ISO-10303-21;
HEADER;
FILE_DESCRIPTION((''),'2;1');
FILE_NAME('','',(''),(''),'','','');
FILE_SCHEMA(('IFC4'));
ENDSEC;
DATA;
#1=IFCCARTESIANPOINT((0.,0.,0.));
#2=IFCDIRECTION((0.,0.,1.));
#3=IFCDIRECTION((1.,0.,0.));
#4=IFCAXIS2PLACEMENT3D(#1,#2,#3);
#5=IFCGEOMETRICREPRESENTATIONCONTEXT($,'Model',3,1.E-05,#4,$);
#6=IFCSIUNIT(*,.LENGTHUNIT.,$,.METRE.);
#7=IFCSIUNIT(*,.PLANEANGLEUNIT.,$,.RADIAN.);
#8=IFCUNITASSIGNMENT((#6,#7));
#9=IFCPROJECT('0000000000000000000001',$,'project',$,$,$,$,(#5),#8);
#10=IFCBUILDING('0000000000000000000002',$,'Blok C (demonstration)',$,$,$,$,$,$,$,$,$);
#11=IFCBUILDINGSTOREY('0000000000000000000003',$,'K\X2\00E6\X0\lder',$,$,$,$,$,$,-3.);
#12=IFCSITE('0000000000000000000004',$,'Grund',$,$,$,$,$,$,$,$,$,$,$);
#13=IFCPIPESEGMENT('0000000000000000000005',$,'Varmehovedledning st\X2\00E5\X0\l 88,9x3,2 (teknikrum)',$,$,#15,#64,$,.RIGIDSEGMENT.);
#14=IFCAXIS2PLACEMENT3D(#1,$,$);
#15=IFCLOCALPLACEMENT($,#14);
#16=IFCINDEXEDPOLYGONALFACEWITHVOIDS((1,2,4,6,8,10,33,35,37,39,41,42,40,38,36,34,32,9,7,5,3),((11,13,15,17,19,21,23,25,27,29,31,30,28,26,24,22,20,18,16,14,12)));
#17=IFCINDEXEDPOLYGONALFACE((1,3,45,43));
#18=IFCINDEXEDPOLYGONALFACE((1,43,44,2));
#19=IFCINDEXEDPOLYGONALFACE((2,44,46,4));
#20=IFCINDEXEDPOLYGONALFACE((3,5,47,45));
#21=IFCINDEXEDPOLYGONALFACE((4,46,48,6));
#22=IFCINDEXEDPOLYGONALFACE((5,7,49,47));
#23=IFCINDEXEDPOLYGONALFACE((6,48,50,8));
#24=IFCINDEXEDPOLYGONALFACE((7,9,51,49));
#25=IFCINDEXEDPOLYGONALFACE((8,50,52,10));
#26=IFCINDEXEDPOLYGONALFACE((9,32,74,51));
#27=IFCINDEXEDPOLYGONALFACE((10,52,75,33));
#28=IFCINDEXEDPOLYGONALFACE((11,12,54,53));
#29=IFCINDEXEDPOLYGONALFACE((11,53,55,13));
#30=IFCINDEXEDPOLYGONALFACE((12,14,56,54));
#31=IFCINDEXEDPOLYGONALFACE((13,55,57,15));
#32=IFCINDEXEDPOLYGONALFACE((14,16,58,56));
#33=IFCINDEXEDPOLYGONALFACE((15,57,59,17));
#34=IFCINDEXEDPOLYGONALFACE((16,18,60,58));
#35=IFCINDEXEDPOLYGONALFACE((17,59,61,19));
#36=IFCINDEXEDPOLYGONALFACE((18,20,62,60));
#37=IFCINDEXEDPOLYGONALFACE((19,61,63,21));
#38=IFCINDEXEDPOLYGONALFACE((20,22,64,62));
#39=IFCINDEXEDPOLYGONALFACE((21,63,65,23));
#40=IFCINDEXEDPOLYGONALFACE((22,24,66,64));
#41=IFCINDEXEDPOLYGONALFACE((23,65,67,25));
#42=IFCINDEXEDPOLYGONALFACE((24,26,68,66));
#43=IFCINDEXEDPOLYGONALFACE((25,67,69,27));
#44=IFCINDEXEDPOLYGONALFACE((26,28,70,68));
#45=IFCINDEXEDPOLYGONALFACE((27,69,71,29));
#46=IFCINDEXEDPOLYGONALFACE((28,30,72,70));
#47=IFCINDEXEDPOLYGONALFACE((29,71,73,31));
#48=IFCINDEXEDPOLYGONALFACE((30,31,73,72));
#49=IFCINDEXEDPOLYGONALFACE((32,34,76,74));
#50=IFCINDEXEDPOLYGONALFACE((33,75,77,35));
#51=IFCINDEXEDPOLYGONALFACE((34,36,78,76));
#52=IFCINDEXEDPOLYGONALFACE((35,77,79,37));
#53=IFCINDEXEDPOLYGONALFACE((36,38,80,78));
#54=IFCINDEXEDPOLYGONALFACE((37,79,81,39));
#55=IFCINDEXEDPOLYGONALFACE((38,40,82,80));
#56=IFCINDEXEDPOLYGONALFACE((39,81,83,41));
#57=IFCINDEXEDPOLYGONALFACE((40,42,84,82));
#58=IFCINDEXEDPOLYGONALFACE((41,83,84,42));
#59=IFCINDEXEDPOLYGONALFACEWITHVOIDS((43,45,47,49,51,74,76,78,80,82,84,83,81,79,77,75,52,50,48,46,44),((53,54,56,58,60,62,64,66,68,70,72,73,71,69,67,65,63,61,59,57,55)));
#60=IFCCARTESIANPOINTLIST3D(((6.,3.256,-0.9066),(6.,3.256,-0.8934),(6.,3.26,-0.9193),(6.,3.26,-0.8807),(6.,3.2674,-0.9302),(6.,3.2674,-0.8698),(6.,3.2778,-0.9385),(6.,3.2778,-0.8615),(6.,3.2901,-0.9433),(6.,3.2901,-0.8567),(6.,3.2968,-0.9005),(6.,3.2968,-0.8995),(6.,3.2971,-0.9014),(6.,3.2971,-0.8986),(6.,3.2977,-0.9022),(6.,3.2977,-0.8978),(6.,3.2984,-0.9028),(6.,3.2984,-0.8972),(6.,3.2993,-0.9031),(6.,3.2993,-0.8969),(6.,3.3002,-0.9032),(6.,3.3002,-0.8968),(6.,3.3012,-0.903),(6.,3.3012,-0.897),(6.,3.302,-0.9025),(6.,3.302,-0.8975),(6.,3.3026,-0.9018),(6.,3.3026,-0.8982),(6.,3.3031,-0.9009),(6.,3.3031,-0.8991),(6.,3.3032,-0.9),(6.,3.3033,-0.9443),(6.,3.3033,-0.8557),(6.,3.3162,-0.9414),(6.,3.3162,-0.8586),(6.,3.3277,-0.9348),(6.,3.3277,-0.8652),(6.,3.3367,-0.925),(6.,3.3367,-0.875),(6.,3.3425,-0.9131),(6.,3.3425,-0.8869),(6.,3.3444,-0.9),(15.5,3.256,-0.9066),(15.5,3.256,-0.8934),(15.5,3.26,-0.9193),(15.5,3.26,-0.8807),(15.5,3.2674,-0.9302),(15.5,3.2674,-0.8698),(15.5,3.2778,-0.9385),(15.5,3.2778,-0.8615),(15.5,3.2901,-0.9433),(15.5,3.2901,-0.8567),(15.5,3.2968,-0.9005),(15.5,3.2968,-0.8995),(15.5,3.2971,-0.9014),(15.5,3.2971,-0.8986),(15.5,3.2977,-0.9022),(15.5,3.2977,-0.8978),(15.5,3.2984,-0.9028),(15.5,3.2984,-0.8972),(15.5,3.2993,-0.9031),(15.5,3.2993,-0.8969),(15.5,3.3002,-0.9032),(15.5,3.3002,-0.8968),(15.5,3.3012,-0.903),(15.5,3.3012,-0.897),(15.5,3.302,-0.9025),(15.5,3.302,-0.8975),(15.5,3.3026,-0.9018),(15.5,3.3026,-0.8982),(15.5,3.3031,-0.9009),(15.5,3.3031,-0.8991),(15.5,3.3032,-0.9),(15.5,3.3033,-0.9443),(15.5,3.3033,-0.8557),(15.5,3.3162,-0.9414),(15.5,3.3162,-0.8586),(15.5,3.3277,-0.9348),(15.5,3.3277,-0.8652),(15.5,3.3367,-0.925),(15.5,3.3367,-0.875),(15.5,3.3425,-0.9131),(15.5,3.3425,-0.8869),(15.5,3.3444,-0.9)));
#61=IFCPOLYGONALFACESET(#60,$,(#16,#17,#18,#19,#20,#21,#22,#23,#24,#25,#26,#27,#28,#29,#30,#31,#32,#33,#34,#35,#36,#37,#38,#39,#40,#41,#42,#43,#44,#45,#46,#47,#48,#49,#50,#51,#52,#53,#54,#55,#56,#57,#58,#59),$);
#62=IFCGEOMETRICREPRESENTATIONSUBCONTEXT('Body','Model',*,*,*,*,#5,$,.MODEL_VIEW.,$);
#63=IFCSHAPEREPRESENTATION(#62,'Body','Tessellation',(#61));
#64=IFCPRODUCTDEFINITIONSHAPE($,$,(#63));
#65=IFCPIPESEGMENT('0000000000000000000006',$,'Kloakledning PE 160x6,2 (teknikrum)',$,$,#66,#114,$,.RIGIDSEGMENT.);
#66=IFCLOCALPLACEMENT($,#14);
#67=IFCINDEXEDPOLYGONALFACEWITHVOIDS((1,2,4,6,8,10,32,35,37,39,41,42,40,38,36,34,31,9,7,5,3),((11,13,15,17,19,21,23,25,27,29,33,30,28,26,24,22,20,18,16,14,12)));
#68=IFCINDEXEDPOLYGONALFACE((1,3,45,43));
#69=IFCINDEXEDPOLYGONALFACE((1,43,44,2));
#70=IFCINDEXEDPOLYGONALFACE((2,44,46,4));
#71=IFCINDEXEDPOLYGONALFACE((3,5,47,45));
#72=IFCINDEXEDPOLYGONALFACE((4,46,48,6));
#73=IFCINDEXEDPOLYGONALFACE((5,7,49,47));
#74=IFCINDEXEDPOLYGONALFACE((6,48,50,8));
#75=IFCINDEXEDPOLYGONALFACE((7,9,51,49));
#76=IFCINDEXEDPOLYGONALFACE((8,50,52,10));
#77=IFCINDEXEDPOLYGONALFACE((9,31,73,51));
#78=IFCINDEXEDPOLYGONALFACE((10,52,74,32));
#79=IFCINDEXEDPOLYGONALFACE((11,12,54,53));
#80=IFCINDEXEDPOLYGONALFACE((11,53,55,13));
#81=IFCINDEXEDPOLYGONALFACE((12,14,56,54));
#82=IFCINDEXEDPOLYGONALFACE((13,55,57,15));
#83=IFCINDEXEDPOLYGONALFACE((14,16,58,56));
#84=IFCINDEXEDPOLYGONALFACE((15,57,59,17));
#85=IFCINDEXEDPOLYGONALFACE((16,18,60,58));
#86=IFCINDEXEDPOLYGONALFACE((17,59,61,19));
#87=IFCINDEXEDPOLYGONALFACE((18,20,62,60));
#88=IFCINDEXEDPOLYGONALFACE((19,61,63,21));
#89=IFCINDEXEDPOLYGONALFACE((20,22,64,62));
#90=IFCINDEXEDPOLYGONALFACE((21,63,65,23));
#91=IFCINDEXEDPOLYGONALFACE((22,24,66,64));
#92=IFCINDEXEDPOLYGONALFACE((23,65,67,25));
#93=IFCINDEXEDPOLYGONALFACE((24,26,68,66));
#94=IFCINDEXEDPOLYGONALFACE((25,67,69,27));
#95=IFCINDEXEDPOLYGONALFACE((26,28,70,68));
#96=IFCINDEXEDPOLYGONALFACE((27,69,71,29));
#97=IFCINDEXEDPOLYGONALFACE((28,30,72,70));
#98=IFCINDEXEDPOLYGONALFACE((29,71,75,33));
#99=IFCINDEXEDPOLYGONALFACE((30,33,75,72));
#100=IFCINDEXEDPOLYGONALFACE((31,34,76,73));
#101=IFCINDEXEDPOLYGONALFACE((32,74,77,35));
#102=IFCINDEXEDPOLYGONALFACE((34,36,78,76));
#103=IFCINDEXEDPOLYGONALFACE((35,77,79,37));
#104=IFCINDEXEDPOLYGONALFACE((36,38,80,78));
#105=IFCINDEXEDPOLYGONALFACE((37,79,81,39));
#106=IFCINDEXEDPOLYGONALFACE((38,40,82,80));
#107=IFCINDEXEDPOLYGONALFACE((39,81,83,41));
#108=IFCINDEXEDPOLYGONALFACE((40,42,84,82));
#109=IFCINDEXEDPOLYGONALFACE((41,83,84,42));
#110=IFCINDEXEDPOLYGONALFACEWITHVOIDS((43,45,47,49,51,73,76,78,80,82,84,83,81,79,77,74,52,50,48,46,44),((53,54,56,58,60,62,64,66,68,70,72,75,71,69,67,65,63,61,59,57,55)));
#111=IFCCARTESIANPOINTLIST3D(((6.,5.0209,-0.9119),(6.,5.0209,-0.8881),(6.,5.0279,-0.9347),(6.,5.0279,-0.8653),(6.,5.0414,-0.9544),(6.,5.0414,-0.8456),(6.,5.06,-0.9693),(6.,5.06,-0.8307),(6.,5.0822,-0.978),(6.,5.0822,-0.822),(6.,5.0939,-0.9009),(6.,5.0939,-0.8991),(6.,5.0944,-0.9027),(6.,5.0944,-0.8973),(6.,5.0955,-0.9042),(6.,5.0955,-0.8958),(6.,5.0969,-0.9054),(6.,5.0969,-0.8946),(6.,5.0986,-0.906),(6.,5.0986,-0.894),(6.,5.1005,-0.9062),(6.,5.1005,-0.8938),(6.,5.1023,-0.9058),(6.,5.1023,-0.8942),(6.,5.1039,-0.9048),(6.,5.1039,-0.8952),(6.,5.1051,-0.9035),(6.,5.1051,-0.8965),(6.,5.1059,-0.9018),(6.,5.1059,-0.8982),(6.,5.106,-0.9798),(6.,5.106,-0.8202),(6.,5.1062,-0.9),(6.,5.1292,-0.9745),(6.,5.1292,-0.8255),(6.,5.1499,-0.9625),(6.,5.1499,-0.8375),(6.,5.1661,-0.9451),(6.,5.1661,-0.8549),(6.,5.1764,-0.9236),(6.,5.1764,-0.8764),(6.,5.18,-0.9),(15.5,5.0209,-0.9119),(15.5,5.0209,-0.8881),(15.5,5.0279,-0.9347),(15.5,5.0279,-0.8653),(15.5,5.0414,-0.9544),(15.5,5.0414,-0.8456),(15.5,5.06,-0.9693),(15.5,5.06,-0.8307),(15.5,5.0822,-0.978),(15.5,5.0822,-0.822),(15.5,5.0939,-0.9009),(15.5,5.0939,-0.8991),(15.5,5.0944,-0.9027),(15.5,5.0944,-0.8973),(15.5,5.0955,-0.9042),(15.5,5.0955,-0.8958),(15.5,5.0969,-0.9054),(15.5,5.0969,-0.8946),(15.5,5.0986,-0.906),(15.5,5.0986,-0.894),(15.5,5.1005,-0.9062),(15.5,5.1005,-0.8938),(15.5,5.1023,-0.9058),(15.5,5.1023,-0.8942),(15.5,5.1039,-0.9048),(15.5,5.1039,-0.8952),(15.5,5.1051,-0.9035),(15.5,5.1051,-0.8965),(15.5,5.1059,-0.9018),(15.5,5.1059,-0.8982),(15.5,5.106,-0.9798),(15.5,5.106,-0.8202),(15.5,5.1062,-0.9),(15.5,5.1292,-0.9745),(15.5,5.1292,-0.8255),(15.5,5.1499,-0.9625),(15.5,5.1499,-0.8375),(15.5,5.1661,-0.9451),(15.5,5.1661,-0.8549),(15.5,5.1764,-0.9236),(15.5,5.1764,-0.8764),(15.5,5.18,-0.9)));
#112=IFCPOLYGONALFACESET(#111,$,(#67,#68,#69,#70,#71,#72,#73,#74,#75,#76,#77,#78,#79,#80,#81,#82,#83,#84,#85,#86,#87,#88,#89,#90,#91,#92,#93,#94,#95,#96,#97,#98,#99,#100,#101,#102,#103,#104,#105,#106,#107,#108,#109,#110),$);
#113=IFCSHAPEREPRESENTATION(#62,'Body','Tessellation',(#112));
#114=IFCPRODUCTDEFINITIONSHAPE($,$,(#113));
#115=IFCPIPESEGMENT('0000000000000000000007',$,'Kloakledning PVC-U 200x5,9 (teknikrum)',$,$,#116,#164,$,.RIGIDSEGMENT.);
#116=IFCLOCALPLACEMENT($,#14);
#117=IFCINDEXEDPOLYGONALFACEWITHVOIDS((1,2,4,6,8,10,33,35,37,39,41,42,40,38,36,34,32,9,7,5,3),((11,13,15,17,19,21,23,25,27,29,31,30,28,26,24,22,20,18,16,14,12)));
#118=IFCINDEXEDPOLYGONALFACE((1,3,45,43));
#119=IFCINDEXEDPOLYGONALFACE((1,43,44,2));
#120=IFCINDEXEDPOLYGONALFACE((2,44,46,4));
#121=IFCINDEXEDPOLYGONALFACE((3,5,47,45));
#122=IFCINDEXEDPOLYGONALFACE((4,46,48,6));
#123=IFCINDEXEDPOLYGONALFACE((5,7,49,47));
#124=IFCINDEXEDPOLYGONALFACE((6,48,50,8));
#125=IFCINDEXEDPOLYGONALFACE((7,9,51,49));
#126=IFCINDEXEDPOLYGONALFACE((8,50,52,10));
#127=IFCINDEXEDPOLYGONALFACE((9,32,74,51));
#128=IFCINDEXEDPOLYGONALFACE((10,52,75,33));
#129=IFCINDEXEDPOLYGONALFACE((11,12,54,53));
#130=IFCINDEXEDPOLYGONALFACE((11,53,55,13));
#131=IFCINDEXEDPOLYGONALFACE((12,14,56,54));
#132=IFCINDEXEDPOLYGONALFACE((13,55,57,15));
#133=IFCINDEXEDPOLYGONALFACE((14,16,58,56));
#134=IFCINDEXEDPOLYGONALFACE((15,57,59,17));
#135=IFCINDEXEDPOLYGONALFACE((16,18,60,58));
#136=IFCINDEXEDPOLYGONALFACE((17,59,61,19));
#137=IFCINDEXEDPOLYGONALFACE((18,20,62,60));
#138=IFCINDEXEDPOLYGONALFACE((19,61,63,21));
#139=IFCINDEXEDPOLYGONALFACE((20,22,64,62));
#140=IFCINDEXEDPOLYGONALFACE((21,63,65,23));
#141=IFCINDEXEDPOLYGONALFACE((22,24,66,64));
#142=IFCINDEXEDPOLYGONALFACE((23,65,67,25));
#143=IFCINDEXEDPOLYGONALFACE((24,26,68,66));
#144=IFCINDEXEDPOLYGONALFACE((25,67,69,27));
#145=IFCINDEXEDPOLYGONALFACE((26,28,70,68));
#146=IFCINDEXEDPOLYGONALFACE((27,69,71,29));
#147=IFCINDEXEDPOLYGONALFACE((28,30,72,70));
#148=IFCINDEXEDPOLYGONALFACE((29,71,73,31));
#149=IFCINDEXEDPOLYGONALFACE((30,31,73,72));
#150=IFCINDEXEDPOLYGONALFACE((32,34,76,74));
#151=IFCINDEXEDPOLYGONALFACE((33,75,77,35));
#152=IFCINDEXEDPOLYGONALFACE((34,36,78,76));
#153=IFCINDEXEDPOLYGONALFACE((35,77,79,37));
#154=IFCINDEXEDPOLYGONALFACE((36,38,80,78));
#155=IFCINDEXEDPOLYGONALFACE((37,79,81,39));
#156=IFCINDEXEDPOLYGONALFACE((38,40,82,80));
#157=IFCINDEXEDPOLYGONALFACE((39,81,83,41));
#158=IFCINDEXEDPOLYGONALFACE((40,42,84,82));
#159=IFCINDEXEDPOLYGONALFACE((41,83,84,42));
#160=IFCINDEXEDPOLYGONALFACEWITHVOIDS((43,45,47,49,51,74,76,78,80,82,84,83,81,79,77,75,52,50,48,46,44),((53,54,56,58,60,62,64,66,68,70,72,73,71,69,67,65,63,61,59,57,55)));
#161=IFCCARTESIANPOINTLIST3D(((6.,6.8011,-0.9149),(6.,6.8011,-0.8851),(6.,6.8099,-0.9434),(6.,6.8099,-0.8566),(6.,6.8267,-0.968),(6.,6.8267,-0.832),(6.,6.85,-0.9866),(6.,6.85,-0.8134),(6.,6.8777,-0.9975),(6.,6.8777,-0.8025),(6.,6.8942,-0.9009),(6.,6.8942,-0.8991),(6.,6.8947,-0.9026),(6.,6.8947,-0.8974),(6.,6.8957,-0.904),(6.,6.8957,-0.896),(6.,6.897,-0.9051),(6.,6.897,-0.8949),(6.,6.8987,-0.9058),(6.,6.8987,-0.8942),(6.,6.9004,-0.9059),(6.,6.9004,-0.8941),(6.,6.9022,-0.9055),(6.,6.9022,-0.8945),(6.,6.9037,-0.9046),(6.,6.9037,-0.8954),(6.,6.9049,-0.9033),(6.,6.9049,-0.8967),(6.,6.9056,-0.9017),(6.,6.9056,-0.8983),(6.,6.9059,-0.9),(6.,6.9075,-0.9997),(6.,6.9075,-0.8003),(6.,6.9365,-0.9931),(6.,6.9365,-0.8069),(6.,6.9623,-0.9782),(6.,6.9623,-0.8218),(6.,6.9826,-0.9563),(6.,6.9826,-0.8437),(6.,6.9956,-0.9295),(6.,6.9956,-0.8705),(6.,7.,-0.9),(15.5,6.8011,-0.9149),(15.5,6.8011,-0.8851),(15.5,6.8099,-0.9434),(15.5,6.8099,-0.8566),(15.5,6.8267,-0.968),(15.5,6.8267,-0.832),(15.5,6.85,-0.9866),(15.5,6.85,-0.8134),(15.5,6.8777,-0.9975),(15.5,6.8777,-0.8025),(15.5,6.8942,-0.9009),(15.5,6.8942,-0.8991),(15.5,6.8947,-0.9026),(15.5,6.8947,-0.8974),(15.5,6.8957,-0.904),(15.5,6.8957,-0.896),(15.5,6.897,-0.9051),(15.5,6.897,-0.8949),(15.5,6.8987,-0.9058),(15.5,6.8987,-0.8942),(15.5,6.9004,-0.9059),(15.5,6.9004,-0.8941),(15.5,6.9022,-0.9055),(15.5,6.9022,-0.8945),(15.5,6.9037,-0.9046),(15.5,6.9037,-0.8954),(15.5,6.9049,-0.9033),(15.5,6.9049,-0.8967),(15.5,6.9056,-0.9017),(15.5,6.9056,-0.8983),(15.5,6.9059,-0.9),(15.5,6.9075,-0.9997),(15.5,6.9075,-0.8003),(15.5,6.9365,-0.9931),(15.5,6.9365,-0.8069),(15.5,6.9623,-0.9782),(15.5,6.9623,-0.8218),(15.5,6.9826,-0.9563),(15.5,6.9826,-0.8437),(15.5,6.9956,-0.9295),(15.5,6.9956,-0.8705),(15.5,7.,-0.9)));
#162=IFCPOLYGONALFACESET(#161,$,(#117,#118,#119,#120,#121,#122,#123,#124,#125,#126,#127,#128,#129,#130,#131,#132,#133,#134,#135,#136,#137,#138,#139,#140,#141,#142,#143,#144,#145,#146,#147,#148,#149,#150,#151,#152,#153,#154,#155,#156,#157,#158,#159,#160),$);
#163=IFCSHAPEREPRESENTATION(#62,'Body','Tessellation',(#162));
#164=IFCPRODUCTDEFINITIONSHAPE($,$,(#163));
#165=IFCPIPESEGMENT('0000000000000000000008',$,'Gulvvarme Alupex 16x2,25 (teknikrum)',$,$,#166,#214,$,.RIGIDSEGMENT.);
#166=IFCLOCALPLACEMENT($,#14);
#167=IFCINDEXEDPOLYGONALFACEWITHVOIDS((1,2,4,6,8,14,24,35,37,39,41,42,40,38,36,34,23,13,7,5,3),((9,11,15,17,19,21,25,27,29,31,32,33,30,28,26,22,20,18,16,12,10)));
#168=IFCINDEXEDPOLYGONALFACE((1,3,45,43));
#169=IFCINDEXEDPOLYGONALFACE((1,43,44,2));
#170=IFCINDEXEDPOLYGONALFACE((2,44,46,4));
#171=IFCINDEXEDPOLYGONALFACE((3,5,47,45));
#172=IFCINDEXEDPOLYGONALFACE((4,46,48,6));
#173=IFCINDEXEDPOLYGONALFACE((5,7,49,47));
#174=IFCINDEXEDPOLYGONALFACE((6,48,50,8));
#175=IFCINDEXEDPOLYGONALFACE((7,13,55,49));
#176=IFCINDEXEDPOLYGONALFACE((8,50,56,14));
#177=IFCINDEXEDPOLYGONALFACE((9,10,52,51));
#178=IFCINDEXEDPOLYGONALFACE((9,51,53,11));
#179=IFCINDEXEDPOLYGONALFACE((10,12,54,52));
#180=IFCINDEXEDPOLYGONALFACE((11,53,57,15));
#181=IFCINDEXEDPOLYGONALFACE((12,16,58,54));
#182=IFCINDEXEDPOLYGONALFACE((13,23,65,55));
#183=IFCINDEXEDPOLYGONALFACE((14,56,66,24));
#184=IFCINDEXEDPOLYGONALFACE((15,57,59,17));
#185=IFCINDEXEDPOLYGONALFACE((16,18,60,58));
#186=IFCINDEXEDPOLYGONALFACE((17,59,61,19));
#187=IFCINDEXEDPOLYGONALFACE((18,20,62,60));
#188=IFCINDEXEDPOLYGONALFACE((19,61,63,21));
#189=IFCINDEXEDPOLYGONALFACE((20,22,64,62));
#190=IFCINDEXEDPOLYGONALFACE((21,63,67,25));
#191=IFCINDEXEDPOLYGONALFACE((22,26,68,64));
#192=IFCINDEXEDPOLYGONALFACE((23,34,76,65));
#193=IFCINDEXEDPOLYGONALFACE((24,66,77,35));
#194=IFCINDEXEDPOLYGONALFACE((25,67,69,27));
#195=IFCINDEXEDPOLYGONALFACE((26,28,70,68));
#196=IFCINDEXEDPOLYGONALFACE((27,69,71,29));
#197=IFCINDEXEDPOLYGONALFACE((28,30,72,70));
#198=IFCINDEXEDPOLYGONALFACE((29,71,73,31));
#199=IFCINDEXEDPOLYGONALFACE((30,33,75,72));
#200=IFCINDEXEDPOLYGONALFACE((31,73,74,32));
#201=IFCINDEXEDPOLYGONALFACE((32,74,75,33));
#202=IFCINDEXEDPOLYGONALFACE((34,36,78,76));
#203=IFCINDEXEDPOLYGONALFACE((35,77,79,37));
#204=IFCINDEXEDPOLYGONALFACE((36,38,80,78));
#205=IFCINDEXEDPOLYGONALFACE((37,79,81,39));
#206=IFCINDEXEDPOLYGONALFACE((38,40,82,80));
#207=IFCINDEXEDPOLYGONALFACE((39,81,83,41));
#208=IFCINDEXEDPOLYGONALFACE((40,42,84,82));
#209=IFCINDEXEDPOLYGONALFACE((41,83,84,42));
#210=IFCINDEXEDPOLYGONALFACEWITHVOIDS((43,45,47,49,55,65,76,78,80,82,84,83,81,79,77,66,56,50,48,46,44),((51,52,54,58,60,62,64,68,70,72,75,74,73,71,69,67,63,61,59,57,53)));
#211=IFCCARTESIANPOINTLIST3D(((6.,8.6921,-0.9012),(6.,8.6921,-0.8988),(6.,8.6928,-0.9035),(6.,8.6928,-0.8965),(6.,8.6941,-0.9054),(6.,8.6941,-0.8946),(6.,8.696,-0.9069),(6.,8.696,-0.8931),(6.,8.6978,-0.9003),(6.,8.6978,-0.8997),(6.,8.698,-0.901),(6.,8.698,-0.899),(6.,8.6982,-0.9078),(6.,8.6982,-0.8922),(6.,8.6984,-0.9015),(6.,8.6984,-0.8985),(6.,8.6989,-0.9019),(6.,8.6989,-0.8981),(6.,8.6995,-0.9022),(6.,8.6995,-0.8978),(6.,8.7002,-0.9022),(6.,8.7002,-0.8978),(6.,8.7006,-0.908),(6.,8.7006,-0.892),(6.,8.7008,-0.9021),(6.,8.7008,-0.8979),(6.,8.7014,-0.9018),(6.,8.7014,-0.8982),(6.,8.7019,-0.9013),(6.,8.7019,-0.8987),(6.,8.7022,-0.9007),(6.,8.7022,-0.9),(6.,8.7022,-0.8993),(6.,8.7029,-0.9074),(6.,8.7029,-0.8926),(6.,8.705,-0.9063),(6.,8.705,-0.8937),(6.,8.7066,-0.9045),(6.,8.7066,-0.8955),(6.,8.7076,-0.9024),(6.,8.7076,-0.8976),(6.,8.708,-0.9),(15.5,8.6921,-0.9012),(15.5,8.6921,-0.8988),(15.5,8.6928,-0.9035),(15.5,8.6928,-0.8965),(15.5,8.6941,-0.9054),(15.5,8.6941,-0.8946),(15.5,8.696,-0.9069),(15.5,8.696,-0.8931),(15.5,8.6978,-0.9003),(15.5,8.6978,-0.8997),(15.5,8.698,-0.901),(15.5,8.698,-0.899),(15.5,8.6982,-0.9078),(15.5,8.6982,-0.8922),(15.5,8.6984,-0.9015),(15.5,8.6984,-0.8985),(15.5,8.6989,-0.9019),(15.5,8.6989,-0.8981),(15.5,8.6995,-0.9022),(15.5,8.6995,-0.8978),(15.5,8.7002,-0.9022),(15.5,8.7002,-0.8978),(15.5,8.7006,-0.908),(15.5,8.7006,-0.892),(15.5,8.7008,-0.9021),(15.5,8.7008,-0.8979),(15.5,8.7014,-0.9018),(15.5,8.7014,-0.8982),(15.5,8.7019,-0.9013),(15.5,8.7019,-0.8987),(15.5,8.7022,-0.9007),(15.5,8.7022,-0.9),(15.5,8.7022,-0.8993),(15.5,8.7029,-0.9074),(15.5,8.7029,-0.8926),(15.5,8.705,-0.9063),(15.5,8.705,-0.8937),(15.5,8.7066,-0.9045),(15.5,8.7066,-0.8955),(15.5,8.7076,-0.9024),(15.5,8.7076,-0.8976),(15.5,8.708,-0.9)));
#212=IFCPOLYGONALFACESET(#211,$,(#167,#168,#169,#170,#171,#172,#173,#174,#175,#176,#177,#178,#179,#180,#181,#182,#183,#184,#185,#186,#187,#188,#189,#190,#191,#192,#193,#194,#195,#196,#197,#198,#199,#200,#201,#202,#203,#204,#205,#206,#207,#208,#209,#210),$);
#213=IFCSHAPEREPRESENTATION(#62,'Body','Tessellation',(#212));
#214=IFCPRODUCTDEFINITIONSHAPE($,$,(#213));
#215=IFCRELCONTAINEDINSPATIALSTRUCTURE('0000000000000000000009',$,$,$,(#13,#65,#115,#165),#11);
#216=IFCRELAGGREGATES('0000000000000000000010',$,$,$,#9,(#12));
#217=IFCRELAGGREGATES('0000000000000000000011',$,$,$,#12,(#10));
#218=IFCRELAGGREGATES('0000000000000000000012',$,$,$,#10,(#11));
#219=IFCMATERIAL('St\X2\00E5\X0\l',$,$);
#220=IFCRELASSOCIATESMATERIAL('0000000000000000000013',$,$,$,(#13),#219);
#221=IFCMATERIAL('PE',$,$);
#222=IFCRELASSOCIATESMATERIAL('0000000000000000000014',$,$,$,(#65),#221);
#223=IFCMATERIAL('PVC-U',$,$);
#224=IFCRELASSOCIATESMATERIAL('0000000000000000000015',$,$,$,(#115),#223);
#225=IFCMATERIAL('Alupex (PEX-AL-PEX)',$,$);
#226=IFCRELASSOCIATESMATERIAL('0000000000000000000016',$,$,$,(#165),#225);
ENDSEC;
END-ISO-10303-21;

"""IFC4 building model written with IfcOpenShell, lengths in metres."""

from ifc_helpers import new_model, si_unit, frame, origin_with_axes, place, context, subcontext, project, spatial, hollow_circle, extrude, material, element, save


model = new_model("IFC4")

# Units and contexts
model_context = context("Model", 3, precision=1e-05, world=origin_with_axes())
body_context = subcontext(model_context, "Body", "Model", "MODEL_VIEW")
ifc_project = project(units=[si_unit("LENGTHUNIT", "METRE"), si_unit("PLANEANGLEUNIT", "RADIAN")], contexts=[model_context])

# Site, building, storey
site = spatial("IfcSite", under=ifc_project, Name="Grund")
building = spatial("IfcBuilding", under=site, Name="Blok C (demonstration)")
storey = spatial("IfcBuildingStorey", under=building, Name="Kælder", Elevation=-3.0)

# Pipe segments
ifc_material_1 = material(Name="PVC-U")
ifc_material_2 = material(Name="Stål")
pipe_segment_1_placement = place(None, origin_with_axes())
element("IfcPipeSegment", 1, at=pipe_segment_1_placement, inside=storey, material=ifc_material_2, Name="Varmehovedledning stål 88,9x3,2 (teknikrum)", PredefinedType="RIGIDSEGMENT", context=body_context, shape_type="SweptSolid", body=[
    extrude(hollow_circle(Radius=0.0445, WallThickness=0.0413), frame((6.0, 3.3, -0.9), z_axis=(1.0, 0.0, 0.0), x_axis=(0.0, 1.0, 0.0)), (0.0, 0.0, 1.0), 9.5),
])
ifc_material_3 = material(Name="PE")
pipe_segment_2_placement = place(None, origin_with_axes())
element("IfcPipeSegment", 2, at=pipe_segment_2_placement, inside=storey, material=ifc_material_3, Name="Kloakledning PE 160x6,2 (teknikrum)", PredefinedType="RIGIDSEGMENT", context=body_context, shape_type="SweptSolid", body=[
    extrude(hollow_circle(Radius=0.08, WallThickness=0.0738), frame((6.0, 5.1, -0.9), z_axis=(1.0, 0.0, 0.0), x_axis=(0.0, 1.0, 0.0)), (0.0, 0.0, 1.0), 9.5),
])
pipe_segment_3_placement = place(None, origin_with_axes())
element("IfcPipeSegment", 3, at=pipe_segment_3_placement, inside=storey, material=ifc_material_1, Name="Kloakledning PVC-U 200x5,9 (teknikrum)", PredefinedType="RIGIDSEGMENT", context=body_context, shape_type="SweptSolid", body=[
    extrude(hollow_circle(Radius=0.1, WallThickness=0.0941), frame((6.0, 6.9, -0.9), z_axis=(1.0, 0.0, 0.0), x_axis=(0.0, 1.0, 0.0)), (0.0, 0.0, 1.0), 9.5),
])
ifc_material_4 = material(Name="Alupex (PEX-AL-PEX)")
pipe_segment_4_placement = place(None, origin_with_axes())
element("IfcPipeSegment", 4, at=pipe_segment_4_placement, inside=storey, material=ifc_material_4, Name="Gulvvarme Alupex 16x2,25 (teknikrum)", PredefinedType="RIGIDSEGMENT", context=body_context, shape_type="SweptSolid", body=[
    extrude(hollow_circle(Radius=0.008, WallThickness=0.0057), frame((6.0, 8.7, -0.9), z_axis=(1.0, 0.0, 0.0), x_axis=(0.0, 1.0, 0.0)), (0.0, 0.0, 1.0), 9.5),
])

save(model, "model.ifc")
